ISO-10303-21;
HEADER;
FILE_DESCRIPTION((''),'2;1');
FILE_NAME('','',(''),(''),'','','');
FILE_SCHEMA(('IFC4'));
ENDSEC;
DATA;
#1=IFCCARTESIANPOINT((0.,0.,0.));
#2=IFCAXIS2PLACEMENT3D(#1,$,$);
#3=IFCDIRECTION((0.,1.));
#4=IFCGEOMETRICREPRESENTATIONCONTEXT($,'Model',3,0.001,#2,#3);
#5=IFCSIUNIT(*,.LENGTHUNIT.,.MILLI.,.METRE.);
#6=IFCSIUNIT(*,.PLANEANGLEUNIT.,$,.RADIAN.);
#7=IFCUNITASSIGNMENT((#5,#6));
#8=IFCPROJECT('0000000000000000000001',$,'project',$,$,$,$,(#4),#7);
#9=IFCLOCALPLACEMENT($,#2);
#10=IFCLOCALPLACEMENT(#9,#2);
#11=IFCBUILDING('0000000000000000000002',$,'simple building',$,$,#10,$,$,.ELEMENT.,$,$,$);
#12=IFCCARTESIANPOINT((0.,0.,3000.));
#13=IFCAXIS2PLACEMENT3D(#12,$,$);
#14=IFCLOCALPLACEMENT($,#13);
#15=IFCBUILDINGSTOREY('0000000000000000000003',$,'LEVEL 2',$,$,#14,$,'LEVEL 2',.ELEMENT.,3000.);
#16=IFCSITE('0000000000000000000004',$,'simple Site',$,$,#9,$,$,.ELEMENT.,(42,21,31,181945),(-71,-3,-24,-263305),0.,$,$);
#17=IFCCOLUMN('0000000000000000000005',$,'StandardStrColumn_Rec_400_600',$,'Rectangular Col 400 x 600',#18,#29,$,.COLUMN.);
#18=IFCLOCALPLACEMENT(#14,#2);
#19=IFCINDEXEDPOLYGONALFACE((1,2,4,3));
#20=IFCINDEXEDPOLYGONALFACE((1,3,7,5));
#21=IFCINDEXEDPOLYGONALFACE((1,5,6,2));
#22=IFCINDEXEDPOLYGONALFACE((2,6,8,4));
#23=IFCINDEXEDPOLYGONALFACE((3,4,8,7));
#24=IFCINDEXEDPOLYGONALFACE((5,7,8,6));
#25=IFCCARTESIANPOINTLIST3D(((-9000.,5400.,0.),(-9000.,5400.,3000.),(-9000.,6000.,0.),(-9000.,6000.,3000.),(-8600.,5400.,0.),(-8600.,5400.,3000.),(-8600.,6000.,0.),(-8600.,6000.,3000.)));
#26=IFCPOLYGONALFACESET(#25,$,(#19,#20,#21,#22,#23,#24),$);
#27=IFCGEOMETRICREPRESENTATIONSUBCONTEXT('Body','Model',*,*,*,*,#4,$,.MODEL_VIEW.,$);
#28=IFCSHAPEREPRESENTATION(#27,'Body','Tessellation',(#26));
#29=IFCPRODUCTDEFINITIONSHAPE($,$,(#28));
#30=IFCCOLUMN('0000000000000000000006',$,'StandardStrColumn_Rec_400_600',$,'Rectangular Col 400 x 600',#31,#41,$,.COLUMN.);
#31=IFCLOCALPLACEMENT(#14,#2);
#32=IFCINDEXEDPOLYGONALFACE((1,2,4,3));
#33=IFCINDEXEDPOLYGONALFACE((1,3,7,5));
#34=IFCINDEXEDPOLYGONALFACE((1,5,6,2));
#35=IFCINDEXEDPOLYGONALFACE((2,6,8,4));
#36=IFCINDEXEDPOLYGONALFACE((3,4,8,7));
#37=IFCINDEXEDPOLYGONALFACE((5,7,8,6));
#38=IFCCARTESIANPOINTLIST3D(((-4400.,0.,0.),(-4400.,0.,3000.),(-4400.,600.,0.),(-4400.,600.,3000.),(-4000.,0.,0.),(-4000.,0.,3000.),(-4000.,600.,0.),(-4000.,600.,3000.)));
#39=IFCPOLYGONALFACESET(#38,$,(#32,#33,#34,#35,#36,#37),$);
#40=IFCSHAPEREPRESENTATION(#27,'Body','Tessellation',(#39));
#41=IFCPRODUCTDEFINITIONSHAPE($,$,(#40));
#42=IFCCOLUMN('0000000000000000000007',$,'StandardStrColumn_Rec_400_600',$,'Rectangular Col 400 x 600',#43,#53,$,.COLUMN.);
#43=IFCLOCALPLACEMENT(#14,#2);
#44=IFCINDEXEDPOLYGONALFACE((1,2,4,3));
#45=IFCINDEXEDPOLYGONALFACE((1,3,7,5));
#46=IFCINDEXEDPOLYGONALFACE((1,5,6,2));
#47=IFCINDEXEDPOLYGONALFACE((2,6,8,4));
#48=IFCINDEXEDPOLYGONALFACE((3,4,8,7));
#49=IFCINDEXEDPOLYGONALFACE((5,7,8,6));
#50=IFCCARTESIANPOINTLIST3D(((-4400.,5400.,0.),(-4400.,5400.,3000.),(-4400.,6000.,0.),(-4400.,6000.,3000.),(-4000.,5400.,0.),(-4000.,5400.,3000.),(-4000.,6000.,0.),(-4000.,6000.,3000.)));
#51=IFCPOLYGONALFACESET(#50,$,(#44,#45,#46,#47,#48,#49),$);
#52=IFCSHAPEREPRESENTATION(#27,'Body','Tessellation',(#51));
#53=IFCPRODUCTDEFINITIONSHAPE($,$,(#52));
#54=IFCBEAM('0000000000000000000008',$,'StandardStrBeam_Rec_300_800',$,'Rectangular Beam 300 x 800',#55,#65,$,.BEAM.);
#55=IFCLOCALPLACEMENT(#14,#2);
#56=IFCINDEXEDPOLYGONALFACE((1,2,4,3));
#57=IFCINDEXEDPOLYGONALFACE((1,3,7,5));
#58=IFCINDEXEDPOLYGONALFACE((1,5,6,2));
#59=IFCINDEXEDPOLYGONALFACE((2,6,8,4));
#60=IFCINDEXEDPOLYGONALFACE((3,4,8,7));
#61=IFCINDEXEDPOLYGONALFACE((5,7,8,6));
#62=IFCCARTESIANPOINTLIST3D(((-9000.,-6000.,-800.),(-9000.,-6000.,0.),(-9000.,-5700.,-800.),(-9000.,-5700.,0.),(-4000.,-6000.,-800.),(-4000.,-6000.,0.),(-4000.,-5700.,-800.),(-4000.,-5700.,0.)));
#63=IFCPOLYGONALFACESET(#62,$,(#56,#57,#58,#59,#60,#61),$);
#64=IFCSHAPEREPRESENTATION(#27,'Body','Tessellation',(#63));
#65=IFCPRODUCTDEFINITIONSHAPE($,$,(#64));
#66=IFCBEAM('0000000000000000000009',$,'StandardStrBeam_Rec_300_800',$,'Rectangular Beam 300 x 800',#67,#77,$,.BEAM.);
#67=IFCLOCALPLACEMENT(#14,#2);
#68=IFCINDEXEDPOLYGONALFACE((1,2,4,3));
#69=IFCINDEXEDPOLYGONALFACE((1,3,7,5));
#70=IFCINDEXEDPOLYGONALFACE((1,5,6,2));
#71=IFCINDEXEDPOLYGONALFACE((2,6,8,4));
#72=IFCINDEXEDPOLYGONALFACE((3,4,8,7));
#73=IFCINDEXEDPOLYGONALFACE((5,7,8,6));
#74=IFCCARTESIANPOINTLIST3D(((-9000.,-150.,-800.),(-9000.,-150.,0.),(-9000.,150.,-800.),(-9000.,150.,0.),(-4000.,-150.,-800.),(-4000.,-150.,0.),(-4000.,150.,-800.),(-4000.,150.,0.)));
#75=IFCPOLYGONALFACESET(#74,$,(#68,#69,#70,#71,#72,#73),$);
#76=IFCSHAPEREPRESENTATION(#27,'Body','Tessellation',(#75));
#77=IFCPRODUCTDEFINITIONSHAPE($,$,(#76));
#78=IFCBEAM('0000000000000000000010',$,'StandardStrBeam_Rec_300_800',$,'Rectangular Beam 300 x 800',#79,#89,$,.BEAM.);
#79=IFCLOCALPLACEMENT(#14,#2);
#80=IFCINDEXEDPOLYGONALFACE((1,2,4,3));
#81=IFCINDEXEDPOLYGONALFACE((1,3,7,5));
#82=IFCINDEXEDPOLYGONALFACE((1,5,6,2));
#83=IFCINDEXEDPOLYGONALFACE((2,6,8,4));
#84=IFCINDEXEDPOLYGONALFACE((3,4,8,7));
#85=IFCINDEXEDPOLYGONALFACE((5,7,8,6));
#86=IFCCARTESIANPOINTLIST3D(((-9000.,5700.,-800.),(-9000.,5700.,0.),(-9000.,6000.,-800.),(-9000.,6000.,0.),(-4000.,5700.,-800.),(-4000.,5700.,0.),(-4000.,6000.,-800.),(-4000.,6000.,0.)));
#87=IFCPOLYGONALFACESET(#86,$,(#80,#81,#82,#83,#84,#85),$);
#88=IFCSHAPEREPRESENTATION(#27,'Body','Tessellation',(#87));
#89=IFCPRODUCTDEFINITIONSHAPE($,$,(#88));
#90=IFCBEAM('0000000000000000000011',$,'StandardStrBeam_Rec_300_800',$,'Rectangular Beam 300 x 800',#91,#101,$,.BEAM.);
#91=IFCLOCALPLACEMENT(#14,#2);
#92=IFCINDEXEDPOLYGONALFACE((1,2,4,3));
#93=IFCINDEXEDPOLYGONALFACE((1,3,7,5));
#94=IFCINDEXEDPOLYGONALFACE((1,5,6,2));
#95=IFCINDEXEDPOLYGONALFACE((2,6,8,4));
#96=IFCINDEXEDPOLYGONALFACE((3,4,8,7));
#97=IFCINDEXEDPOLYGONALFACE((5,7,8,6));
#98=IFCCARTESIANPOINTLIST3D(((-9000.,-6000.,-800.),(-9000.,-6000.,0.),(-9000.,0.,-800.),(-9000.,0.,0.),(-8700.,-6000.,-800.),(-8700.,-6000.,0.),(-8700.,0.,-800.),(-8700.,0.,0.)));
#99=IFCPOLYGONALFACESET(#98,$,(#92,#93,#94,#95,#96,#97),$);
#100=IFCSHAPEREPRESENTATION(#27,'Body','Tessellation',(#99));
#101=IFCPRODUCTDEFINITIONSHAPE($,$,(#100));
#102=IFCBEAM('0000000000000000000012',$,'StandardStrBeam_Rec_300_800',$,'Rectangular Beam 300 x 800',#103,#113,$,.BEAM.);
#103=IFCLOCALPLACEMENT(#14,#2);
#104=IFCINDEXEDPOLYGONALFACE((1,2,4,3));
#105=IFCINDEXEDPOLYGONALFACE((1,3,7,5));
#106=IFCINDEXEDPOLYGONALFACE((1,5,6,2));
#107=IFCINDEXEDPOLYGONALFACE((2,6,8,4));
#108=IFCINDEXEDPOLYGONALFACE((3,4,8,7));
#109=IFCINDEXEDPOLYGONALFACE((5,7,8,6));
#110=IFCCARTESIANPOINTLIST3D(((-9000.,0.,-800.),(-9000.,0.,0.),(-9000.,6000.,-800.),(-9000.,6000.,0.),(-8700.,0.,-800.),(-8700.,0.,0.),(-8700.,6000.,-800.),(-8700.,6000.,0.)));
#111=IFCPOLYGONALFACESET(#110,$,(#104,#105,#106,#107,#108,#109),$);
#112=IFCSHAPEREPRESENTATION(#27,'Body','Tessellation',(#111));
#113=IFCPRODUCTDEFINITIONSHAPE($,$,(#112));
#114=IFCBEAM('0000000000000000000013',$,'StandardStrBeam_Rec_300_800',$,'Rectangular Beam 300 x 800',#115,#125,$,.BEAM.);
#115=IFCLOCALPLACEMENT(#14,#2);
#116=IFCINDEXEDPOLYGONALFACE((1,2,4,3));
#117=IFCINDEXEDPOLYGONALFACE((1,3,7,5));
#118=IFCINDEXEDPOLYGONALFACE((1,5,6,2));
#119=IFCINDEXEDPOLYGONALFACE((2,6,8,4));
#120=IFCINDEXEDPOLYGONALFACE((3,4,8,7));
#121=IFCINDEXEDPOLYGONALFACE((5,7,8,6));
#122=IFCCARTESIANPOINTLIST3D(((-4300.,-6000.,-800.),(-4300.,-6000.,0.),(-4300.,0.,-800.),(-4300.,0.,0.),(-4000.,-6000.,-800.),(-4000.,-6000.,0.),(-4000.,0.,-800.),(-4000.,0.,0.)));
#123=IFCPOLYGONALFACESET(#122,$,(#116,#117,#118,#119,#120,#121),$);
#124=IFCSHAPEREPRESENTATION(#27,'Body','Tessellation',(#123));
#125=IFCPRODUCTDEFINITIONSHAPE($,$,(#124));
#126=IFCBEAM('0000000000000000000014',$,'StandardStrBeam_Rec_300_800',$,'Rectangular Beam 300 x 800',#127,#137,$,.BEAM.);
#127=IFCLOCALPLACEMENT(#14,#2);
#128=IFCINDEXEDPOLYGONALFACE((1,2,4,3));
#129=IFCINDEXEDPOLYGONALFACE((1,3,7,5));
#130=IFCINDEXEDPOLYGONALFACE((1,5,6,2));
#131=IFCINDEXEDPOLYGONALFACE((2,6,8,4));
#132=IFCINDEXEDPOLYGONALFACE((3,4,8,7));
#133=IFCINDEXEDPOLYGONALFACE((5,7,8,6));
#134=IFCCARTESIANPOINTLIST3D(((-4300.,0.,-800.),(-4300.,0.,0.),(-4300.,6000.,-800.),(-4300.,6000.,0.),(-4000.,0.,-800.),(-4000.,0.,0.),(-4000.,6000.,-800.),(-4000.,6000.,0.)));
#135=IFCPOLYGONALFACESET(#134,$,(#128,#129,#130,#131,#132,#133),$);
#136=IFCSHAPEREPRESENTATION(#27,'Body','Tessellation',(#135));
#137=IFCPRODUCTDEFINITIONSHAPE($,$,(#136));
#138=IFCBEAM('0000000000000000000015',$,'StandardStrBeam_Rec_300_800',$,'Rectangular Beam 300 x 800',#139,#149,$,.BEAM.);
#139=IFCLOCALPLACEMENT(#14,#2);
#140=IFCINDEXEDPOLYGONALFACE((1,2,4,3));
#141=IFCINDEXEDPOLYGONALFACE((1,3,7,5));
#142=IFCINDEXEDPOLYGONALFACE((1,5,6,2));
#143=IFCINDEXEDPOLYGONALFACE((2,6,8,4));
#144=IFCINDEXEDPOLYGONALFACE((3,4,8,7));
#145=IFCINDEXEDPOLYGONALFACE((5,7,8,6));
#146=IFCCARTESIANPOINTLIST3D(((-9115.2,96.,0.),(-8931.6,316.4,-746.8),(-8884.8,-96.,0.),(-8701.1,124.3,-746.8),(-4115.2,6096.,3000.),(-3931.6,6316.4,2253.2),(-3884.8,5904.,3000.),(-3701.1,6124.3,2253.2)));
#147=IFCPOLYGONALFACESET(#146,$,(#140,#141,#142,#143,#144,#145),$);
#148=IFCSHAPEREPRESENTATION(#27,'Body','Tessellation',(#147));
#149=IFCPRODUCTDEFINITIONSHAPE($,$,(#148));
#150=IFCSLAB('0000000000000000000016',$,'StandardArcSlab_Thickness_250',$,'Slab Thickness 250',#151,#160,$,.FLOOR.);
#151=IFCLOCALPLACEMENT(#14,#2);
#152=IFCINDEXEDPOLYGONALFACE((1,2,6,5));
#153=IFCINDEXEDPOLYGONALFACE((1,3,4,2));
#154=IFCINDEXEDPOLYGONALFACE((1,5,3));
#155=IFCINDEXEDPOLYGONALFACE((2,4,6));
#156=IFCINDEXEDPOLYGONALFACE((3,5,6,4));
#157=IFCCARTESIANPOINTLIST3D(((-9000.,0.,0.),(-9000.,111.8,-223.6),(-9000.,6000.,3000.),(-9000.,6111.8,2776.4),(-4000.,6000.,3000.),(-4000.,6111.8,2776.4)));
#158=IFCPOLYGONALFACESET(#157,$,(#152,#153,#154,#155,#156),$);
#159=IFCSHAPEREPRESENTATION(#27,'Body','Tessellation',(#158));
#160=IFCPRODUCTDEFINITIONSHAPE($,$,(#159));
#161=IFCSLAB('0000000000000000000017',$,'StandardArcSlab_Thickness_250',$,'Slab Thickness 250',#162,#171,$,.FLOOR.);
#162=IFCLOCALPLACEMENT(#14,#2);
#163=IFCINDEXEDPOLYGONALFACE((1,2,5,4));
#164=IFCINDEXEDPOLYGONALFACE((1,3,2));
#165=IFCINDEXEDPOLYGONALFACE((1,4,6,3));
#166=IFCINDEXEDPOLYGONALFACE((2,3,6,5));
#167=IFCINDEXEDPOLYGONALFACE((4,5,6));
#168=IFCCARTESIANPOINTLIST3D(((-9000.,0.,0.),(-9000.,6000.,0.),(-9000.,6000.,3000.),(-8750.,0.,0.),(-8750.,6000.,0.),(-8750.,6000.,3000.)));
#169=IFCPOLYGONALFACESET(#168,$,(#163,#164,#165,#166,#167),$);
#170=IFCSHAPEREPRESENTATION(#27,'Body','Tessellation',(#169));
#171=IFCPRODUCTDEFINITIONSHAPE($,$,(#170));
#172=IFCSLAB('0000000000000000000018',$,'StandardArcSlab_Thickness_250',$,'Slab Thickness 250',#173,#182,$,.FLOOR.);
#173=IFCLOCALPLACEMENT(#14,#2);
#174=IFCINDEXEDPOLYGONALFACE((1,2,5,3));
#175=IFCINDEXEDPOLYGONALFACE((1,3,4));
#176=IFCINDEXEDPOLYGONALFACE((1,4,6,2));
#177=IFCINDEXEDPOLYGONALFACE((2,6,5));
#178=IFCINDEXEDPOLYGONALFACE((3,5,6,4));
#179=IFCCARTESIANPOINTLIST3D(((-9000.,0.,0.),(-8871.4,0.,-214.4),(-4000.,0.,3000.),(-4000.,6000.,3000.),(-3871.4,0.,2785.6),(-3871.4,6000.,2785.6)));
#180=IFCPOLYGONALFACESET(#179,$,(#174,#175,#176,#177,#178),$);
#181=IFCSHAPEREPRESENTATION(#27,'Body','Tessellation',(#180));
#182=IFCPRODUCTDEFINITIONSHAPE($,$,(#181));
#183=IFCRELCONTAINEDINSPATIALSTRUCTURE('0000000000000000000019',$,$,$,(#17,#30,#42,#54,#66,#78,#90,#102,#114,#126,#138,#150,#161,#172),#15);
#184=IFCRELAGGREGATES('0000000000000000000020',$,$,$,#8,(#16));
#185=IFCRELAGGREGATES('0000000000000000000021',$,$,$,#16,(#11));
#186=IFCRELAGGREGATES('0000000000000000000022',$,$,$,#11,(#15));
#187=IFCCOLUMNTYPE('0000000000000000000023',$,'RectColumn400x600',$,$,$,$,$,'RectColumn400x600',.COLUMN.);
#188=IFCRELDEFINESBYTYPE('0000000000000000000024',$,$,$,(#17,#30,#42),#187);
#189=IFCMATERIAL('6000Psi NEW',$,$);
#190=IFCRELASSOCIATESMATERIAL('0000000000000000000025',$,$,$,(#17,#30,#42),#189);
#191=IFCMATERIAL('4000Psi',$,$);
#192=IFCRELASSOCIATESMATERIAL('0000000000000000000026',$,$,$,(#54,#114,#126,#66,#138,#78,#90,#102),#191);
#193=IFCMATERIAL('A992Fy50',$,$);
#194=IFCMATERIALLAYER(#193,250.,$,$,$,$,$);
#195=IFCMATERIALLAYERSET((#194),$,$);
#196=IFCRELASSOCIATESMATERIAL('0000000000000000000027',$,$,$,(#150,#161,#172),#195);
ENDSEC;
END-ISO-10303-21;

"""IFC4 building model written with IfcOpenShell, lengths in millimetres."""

from ifc_helpers import new_model, si_unit, direction, frame, origin, origin_with_axes, origin_2d_with_axis, place, context, subcontext, project, spatial, polyline, rectangle, outline, extrude, material, layer, layer_set, layer_usage, material_profile, profile_set, profile_usage, type_object, element, save


model = new_model("IFC4")

# Units and contexts
model_context = context("Model", 3, precision=0.001, world=origin(), true_north=direction((0.0, 1.0)))
body_context = subcontext(model_context, "Body", "Model", "MODEL_VIEW")
ifc_project = project(units=[si_unit("LENGTHUNIT", "METRE", prefix="MILLI"), si_unit("PLANEANGLEUNIT", "RADIAN")], contexts=[model_context])

# Site, building, storey
site_placement = place(None, origin())
site = spatial("IfcSite", under=ifc_project, at=site_placement, Name="simple Site", CompositionType="ELEMENT", RefLatitude=(42, 21, 31, 181945), RefLongitude=(-71, -3, -24, -263305), RefElevation=0.0)
building_placement = place(site_placement, origin())
building = spatial("IfcBuilding", under=site, at=building_placement, Name="simple building", CompositionType="ELEMENT")
storey_placement = place(None, frame((0.0, 0.0, 3000.0)))
storey = spatial("IfcBuildingStorey", under=building, at=storey_placement, Name="LEVEL 2", LongName="LEVEL 2", CompositionType="ELEMENT", Elevation=3000.0)

# Columns
ifc_material_1 = material(Name="6000Psi NEW")
ifc_material_profile_1 = material_profile(ifc_material_1, rectangle(XDim=400.0, YDim=600.0, at=origin_2d_with_axis()))
ifc_profile_set_1 = profile_set([ifc_material_profile_1])
ifc_profile_usage_1 = profile_usage(ifc_profile_set_1, cardinal=1)
column_type = type_object("IfcColumnType", Name="RectColumn400x600", ElementType="RectColumn400x600", PredefinedType="COLUMN")
column_1_placement = place(None, frame((-8800.0, 5700.0, 3000.0), z_axis=(0.0, 0.0, 1.0), x_axis=(1.0, 0.0, 0.0)))
element("IfcColumn", 1, at=column_1_placement, inside=storey, type_object=column_type, material=ifc_profile_usage_1, Name="StandardStrColumn_Rec_400_600", ObjectType="Rectangular Col 400 x 600", PredefinedType="COLUMN", context=body_context, shape_type="SweptSolid", body=[
    extrude(rectangle(XDim=400.0, YDim=600.0, at=origin_2d_with_axis()), origin_with_axes(), (0.0, 0.0, 1.0), 3000.0),
])
ifc_profile_usage_2 = profile_usage(ifc_profile_set_1, cardinal=9)
column_2_placement = place(None, frame((-4200.0, 300.0, 3000.0), z_axis=(0.0, 0.0, 1.0), x_axis=(1.0, 0.0, 0.0)))
element("IfcColumn", 2, at=column_2_placement, inside=storey, type_object=column_type, material=ifc_profile_usage_2, Name="StandardStrColumn_Rec_400_600", ObjectType="Rectangular Col 400 x 600", PredefinedType="COLUMN", context=body_context, shape_type="SweptSolid", body=[
    extrude(rectangle(XDim=400.0, YDim=600.0, at=origin_2d_with_axis()), origin_with_axes(), (0.0, 0.0, 1.0), 3000.0),
])
ifc_profile_usage_3 = profile_usage(ifc_profile_set_1, cardinal=3)
column_3_placement = place(None, frame((-4200.0, 5700.0, 3000.0), z_axis=(0.0, 0.0, 1.0), x_axis=(1.0, 0.0, 0.0)))
element("IfcColumn", 3, at=column_3_placement, inside=storey, type_object=column_type, material=ifc_profile_usage_3, Name="StandardStrColumn_Rec_400_600", ObjectType="Rectangular Col 400 x 600", PredefinedType="COLUMN", context=body_context, shape_type="SweptSolid", body=[
    extrude(rectangle(XDim=400.0, YDim=600.0, at=origin_2d_with_axis()), origin_with_axes(), (0.0, 0.0, 1.0), 3000.0),
])

# Beams
ifc_material_2 = material(Name="4000Psi")
ifc_material_profile_2 = material_profile(ifc_material_2, rectangle(XDim=300.0, YDim=800.0, at=origin_2d_with_axis()))
ifc_profile_set_2 = profile_set([ifc_material_profile_2])
ifc_profile_usage_4 = profile_usage(ifc_profile_set_2, cardinal=9)
beam_1_placement = place(None, frame((-9000.0, -5850.0, 2600.0), z_axis=(1.0, 0.0, 0.0), x_axis=(0.0, -1.0, 0.0)))
element("IfcBeam", 4, at=beam_1_placement, inside=storey, material=ifc_profile_usage_4, Name="StandardStrBeam_Rec_300_800", ObjectType="Rectangular Beam 300 x 800", PredefinedType="BEAM", context=body_context, shape_type="SweptSolid", body=[
    extrude(rectangle(XDim=300.0, YDim=800.0, at=origin_2d_with_axis()), origin_with_axes(), (0.0, 0.0, 1.0), 5000.0),
])
ifc_profile_usage_5 = profile_usage(ifc_profile_set_2, cardinal=8)
beam_2_placement = place(None, frame((-9000.0, 0.0, 2600.0), z_axis=(1.0, 0.0, 0.0), x_axis=(0.0, -1.0, 0.0)))
element("IfcBeam", 5, at=beam_2_placement, inside=storey, material=ifc_profile_usage_5, Name="StandardStrBeam_Rec_300_800", ObjectType="Rectangular Beam 300 x 800", PredefinedType="BEAM", context=body_context, shape_type="SweptSolid", body=[
    extrude(rectangle(XDim=300.0, YDim=800.0, at=origin_2d_with_axis()), origin_with_axes(), (0.0, 0.0, 1.0), 5000.0),
])
ifc_profile_usage_6 = profile_usage(ifc_profile_set_2, cardinal=7)
beam_3_placement = place(None, frame((-9000.0, 5850.0, 2600.0), z_axis=(1.0, 0.0, 0.0), x_axis=(0.0, -1.0, 0.0)))
element("IfcBeam", 6, at=beam_3_placement, inside=storey, material=ifc_profile_usage_6, Name="StandardStrBeam_Rec_300_800", ObjectType="Rectangular Beam 300 x 800", PredefinedType="BEAM", context=body_context, shape_type="SweptSolid", body=[
    extrude(rectangle(XDim=300.0, YDim=800.0, at=origin_2d_with_axis()), origin_with_axes(), (0.0, 0.0, 1.0), 5000.0),
])
for number, where, z_axis, x_axis, name in (
    (7, (-8850.0, -6000.0, 2600.0), (0.0, 1.0, 0.0), (1.0, 0.0, 0.0), "StandardStrBeam_Rec_300_800"),
    (8, (-8850.0, 0.0, 2600.0), (0.0, 1.0, 0.0), (1.0, 0.0, 0.0), "StandardStrBeam_Rec_300_800"),
):
    element("IfcBeam", number, at=place(None, frame(where, z_axis=z_axis, x_axis=x_axis)), inside=storey, material=ifc_profile_usage_6, Name=name, ObjectType="Rectangular Beam 300 x 800", PredefinedType="BEAM", context=body_context, shape_type="SweptSolid", body=[
        extrude(rectangle(XDim=300.0, YDim=800.0, at=origin_2d_with_axis()), origin_with_axes(), (0.0, 0.0, 1.0), 6000.0),
    ])
for number, where, z_axis, x_axis, name in (
    (9, (-4150.0, -6000.0, 2600.0), (0.0, 1.0, 0.0), (1.0, 0.0, 0.0), "StandardStrBeam_Rec_300_800"),
    (10, (-4150.0, 0.0, 2600.0), (0.0, 1.0, 0.0), (1.0, 0.0, 0.0), "StandardStrBeam_Rec_300_800"),
):
    element("IfcBeam", number, at=place(None, frame(where, z_axis=z_axis, x_axis=x_axis)), inside=storey, material=ifc_profile_usage_4, Name=name, ObjectType="Rectangular Beam 300 x 800", PredefinedType="BEAM", context=body_context, shape_type="SweptSolid", body=[
        extrude(rectangle(XDim=300.0, YDim=800.0, at=origin_2d_with_axis()), origin_with_axes(), (0.0, 0.0, 1.0), 6000.0),
    ])
beam_4_placement = place(None, frame((-8908.2, 110.2, 2626.6), z_axis=(0.597614, 0.717137, 0.358569), x_axis=(0.768221, -0.640184, 0.0)))
element("IfcBeam", 11, at=beam_4_placement, inside=storey, material=ifc_profile_usage_5, Name="StandardStrBeam_Rec_300_800", ObjectType="Rectangular Beam 300 x 800", PredefinedType="BEAM", context=body_context, shape_type="SweptSolid", body=[
    extrude(rectangle(XDim=300.0, YDim=800.0, at=origin_2d_with_axis()), origin_with_axes(), (0.0, 0.0, 1.0), 8366.6),
])

# Slabs
ifc_material_3 = material(Name="A992Fy50")
ifc_layer = layer(ifc_material_3, 250.0)
ifc_layer_set = layer_set([ifc_layer])
ifc_layer_usage = layer_usage(ifc_layer_set, "AXIS3", "POSITIVE", -250.0)
slab_1_placement = place(None, frame((-9000.0, 6111.8, 5776.4), z_axis=(0.0, -0.447214, 0.894427), x_axis=(0.0, -0.894427, -0.447214)))
element("IfcSlab", 12, at=slab_1_placement, inside=storey, material=ifc_layer_usage, Name="StandardArcSlab_Thickness_250", ObjectType="Slab Thickness 250", PredefinedType="FLOOR", context=body_context, shape_type="SweptSolid", body=[
    extrude(outline(polyline([(0.0, 0.0), (6708.2, 0.0), (0.0, 5000.0), (0.0, 0.0)])), origin_with_axes(), (0.0, 0.0, 1.0), 250.0),
])
slab_2_placement = place(None, frame((-8750.0, 6000.0, 3000.0), z_axis=(-1.0, 0.0, 0.0), x_axis=(0.0, -1.0, 0.0)))
element("IfcSlab", 13, at=slab_2_placement, inside=storey, material=ifc_layer_usage, Name="StandardArcSlab_Thickness_250", ObjectType="Slab Thickness 250", PredefinedType="FLOOR", context=body_context, shape_type="SweptSolid", body=[
    extrude(outline(polyline([(0.0, 0.0), (6000.0, 0.0), (0.0, 3000.0), (0.0, 0.0)])), origin_with_axes(), (0.0, 0.0, 1.0), 250.0),
])
slab_3_placement = place(None, frame((-8871.4, 0.0, 2785.6), z_axis=(-0.514496, 0.0, 0.857493), x_axis=(0.857493, 0.0, 0.514496)))
element("IfcSlab", 14, at=slab_3_placement, inside=storey, material=ifc_layer_usage, Name="StandardArcSlab_Thickness_250", ObjectType="Slab Thickness 250", PredefinedType="FLOOR", context=body_context, shape_type="SweptSolid", body=[
    extrude(outline(polyline([(0.0, 0.0), (5831.0, 0.0), (5831.0, 6000.0), (0.0, 0.0)])), origin_with_axes(), (0.0, 0.0, 1.0), 250.0),
])

save(model, "model.ifc")
